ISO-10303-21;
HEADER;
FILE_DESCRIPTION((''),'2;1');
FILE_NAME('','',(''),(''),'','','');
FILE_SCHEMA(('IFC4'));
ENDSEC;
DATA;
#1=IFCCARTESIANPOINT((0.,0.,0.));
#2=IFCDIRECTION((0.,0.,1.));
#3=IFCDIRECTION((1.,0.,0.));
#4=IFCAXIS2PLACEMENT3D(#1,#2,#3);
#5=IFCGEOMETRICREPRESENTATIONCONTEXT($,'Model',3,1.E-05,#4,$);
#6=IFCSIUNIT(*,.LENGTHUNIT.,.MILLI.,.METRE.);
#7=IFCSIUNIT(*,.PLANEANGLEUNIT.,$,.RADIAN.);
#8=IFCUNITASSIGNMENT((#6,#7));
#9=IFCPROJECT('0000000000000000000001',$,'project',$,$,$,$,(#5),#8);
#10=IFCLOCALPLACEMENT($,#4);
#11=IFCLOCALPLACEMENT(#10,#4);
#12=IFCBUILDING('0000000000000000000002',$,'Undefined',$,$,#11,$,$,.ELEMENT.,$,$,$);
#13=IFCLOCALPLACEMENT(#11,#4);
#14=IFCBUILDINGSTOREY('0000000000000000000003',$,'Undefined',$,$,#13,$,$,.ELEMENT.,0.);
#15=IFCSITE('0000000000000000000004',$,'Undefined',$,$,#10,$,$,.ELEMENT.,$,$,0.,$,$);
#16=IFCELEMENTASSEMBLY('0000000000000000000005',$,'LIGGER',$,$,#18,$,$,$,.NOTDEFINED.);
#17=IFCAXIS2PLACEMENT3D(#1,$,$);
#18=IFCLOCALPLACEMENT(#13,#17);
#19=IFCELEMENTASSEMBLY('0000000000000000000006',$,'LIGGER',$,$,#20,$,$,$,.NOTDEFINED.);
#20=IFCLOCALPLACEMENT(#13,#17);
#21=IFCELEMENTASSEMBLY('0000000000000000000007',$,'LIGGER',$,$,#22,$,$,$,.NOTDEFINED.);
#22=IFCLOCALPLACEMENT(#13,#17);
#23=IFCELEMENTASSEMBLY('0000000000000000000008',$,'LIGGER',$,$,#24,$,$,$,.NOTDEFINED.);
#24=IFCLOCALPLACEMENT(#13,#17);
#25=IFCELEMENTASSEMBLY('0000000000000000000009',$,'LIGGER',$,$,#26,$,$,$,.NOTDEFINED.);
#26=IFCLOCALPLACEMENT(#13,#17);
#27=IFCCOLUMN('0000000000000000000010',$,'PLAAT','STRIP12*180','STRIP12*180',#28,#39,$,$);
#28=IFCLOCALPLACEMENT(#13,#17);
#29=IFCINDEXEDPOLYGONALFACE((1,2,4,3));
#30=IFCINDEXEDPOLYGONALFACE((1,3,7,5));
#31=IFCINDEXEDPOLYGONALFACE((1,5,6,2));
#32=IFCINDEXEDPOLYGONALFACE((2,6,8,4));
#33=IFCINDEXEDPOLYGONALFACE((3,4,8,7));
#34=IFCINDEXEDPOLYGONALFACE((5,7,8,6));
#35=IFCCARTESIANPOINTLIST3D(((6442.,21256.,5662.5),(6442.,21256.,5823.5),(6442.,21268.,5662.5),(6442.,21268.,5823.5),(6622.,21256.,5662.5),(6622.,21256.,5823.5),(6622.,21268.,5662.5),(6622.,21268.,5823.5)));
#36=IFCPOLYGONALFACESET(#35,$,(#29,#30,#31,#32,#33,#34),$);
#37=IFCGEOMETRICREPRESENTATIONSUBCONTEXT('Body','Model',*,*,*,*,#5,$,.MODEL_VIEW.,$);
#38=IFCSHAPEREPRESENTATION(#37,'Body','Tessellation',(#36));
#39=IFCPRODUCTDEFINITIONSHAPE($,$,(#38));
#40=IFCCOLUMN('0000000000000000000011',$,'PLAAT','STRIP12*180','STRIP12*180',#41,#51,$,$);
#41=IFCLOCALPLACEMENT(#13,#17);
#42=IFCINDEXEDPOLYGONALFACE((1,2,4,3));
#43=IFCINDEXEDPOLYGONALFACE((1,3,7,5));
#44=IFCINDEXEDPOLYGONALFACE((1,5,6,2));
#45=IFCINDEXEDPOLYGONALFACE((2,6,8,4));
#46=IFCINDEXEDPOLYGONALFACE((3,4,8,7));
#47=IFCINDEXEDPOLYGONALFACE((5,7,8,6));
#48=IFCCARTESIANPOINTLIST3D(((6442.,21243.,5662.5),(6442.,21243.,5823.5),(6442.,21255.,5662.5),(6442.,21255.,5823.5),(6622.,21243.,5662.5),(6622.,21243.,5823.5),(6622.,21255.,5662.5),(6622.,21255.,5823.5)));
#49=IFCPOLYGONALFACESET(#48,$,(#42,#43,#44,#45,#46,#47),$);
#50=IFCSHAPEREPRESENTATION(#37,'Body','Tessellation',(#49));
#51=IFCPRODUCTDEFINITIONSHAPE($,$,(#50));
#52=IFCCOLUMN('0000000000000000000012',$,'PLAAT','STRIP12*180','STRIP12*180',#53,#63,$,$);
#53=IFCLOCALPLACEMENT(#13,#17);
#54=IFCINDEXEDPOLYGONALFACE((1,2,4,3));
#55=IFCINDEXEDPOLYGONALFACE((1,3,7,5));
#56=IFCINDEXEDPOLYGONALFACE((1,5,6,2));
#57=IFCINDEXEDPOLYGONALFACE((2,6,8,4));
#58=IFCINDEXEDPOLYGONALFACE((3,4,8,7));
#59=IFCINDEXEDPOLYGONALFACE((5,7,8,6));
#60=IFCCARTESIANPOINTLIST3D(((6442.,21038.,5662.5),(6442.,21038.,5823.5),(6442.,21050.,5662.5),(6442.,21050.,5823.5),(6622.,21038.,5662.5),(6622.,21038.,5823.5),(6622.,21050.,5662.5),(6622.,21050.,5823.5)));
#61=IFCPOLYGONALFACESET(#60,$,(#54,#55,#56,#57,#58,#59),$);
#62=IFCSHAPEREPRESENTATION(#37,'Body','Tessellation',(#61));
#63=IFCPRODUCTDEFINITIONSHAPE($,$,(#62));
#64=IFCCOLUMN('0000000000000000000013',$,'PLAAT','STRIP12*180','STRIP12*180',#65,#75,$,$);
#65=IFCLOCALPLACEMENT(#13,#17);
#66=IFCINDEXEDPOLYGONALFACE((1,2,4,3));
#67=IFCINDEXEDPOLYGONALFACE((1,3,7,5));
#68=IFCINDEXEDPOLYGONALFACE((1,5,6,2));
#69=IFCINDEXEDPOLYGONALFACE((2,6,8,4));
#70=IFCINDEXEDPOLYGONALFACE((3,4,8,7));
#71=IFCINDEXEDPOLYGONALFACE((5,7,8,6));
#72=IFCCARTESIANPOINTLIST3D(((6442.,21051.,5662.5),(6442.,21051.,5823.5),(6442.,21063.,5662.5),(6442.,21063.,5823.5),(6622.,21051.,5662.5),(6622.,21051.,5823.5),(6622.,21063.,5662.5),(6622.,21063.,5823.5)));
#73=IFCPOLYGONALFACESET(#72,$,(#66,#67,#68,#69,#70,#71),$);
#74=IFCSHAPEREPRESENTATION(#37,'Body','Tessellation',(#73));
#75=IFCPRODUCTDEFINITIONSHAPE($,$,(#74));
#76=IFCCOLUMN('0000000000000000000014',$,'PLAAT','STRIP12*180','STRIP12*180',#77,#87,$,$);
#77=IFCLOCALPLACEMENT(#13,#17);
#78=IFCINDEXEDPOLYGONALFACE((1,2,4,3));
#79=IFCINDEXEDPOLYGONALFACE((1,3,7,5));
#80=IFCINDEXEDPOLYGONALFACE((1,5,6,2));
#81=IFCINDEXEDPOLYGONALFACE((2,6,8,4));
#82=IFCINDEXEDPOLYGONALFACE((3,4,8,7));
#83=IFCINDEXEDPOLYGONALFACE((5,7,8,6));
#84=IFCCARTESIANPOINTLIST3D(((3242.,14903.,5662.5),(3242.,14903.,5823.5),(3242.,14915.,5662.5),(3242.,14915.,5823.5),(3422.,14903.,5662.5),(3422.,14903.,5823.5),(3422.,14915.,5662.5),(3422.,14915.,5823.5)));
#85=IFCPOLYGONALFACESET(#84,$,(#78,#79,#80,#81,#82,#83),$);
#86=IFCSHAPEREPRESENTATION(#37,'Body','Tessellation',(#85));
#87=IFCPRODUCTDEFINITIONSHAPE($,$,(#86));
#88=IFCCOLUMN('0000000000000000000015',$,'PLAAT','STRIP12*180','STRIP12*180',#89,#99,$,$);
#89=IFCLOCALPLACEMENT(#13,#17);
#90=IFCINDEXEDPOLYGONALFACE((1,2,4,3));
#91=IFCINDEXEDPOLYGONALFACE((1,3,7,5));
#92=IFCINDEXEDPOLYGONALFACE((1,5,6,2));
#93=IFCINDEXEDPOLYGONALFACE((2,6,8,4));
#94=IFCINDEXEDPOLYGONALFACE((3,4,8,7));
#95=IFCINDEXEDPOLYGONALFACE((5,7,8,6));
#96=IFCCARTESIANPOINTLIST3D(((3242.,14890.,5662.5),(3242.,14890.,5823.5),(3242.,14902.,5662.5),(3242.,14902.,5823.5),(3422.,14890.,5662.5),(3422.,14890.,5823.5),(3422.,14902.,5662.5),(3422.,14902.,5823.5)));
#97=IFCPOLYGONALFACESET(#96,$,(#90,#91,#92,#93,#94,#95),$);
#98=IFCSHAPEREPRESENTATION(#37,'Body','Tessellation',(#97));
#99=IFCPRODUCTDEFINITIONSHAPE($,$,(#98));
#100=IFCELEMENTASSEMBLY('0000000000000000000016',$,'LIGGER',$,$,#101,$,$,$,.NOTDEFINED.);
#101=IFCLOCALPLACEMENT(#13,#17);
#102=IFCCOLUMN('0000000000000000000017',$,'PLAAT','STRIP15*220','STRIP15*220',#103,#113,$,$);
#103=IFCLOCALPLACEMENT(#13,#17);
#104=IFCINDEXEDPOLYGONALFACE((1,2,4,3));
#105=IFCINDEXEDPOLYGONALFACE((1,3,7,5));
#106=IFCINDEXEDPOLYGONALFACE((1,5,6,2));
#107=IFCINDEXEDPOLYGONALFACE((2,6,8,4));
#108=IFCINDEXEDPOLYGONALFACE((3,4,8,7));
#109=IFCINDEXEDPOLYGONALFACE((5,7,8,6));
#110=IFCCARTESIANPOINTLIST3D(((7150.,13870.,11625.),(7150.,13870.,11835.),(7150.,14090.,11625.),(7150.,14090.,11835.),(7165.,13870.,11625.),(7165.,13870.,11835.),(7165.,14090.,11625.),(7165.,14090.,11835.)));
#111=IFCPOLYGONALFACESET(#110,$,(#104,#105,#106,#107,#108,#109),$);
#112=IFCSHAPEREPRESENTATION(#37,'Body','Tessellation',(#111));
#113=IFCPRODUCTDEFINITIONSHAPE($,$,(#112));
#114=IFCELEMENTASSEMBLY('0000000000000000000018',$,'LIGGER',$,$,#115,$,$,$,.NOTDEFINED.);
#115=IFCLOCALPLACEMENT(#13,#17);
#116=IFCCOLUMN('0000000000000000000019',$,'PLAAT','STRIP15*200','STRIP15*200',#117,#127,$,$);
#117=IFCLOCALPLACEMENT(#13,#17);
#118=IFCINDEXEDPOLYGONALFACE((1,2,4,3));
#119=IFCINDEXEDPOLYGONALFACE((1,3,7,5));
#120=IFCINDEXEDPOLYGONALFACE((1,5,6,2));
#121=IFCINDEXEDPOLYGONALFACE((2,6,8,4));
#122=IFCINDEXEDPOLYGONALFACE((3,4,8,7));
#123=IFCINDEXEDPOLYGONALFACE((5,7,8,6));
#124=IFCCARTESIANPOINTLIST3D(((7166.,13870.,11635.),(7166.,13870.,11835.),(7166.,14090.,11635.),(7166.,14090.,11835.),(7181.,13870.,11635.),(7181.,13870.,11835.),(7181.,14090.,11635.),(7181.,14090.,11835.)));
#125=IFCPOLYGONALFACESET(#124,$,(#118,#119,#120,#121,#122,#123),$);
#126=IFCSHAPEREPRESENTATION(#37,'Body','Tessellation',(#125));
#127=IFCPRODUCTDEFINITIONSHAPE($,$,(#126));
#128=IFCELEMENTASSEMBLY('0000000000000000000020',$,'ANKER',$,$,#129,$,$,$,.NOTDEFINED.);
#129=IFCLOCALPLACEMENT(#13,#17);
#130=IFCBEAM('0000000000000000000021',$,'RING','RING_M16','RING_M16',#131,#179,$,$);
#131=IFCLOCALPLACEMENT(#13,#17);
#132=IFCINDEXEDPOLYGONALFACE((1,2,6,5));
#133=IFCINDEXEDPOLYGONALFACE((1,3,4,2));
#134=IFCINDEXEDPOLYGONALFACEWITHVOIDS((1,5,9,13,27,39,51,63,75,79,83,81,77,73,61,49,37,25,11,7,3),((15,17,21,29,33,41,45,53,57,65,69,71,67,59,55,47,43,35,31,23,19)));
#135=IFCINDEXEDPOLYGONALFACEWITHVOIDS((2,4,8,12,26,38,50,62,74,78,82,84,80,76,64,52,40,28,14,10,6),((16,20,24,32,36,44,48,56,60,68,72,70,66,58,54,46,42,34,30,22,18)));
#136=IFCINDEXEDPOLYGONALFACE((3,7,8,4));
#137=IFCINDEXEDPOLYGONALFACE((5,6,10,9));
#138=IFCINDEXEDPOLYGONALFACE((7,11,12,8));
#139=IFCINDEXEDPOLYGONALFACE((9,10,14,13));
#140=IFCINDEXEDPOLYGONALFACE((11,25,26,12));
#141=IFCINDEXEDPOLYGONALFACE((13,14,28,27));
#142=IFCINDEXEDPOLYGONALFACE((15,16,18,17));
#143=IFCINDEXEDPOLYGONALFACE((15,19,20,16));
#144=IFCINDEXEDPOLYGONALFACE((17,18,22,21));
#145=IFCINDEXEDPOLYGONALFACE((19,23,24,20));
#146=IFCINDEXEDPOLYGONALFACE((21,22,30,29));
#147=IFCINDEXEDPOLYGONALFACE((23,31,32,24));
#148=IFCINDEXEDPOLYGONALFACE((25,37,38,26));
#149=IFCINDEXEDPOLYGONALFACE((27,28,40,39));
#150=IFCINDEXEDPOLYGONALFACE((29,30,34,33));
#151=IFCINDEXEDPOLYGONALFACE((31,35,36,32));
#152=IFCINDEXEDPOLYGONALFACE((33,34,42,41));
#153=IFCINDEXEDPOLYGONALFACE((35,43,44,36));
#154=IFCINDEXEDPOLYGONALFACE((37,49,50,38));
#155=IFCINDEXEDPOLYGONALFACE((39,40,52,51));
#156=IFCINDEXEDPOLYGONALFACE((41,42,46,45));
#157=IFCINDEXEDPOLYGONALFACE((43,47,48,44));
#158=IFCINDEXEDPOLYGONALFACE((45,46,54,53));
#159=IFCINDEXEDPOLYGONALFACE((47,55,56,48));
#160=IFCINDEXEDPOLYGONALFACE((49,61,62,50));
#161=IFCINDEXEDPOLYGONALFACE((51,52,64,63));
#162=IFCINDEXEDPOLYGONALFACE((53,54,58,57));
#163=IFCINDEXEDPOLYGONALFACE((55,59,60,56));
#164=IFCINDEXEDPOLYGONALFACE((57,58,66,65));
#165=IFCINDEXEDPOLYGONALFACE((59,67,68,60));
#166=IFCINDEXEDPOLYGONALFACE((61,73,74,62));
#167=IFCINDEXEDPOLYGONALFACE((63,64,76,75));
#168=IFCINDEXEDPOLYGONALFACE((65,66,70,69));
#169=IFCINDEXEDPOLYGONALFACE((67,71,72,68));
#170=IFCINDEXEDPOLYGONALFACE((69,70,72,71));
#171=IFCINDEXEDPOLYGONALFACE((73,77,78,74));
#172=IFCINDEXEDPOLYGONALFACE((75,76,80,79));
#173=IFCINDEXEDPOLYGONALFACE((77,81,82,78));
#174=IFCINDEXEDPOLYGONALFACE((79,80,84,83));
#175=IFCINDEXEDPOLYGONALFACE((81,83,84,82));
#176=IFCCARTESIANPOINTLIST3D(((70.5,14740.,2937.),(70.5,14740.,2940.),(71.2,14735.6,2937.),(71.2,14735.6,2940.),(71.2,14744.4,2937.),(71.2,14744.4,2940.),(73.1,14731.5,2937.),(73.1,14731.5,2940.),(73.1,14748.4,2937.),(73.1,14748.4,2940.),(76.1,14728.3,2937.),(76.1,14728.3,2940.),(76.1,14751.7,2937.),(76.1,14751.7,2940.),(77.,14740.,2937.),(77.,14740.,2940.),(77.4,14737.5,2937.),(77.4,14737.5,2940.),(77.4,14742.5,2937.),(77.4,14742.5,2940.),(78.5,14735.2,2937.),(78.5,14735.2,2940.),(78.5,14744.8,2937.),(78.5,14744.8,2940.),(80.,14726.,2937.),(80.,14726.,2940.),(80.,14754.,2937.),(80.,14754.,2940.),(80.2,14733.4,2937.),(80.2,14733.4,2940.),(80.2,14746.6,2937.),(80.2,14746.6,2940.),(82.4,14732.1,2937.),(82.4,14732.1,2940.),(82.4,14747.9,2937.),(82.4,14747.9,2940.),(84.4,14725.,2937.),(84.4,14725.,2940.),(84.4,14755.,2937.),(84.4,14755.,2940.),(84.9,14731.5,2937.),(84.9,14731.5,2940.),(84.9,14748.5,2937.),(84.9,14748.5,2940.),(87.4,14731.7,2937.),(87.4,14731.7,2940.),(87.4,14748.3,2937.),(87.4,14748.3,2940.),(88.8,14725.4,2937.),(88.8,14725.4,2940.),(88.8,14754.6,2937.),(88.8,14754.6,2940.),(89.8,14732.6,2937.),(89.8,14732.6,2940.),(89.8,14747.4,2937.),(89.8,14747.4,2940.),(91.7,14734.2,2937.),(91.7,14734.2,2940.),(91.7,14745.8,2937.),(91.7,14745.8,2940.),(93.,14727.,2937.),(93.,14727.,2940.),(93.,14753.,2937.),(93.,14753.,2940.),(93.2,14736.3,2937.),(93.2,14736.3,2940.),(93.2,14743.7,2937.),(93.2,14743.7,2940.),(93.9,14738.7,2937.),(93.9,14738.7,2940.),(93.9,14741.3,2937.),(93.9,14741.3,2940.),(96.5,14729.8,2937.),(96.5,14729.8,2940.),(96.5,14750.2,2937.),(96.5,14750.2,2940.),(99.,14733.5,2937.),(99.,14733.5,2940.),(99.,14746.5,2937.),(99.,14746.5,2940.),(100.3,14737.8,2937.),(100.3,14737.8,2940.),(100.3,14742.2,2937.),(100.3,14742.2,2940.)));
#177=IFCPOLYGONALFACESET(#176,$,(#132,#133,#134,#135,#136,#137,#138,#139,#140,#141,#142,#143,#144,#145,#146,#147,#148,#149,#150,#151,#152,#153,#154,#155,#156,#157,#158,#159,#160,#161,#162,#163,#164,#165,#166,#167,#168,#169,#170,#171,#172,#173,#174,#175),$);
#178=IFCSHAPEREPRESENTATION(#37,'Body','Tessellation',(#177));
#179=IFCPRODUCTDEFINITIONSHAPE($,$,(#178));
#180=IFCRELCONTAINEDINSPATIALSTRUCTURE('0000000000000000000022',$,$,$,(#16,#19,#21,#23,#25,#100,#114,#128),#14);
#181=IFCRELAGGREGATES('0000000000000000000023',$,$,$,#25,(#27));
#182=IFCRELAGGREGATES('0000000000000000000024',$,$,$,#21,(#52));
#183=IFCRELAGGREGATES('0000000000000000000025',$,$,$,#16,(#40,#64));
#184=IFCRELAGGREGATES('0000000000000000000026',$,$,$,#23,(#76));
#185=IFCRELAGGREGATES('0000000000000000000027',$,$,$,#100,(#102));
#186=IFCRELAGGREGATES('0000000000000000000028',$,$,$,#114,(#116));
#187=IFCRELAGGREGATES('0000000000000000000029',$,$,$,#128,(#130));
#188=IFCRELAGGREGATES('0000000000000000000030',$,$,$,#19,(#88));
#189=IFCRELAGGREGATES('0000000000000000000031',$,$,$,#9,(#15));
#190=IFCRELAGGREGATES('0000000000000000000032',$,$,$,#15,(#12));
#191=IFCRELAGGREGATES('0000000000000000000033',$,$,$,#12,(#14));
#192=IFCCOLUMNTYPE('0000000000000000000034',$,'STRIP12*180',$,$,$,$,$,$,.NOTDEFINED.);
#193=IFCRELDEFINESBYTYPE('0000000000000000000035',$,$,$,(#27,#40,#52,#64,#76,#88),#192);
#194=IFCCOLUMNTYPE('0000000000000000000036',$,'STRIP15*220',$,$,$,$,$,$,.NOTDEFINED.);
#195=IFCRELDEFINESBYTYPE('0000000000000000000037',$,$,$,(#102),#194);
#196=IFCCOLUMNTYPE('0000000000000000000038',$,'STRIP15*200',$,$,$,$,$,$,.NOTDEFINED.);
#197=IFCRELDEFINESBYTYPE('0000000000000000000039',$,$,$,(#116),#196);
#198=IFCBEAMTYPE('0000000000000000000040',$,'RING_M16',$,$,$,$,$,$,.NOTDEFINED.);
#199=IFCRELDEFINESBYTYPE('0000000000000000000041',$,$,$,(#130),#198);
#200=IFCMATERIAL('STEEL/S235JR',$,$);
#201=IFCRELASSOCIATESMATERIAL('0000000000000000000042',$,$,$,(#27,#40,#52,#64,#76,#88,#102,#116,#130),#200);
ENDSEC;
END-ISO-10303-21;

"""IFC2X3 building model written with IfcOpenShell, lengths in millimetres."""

from ifc_helpers import new_model, si_unit, frame, origin_with_axes, origin_2d_with_axis, place, context, subcontext, project, spatial, rectangle, hollow_circle, extrude, material, type_object, element, aggregate, save


model = new_model("IFC2X3")

# Units and contexts
model_context = context("Model", 3, precision=1e-05, world=origin_with_axes())
body_context = subcontext(model_context, "Body", "Model", "MODEL_VIEW")
ifc_project = project(units=[si_unit("LENGTHUNIT", "METRE", prefix="MILLI"), si_unit("PLANEANGLEUNIT", "RADIAN")], contexts=[model_context])

# Site, building, storey
site_placement = place(None, origin_with_axes())
site = spatial("IfcSite", under=ifc_project, at=site_placement, Name="Undefined", CompositionType="ELEMENT", RefElevation=0.0)
building_placement = place(site_placement, origin_with_axes())
building = spatial("IfcBuilding", under=site, at=building_placement, Name="Undefined", CompositionType="ELEMENT")
storey_placement = place(building_placement, origin_with_axes())
storey = spatial("IfcBuildingStorey", under=building, at=storey_placement, Name="Undefined", CompositionType="ELEMENT", Elevation=0.0)

# Element assembly
assembly_1_placement = place(storey_placement, frame((7775.0, 21153.0, 5743.0), z_axis=(0.0, 0.0, 1.0), x_axis=(-1.0, 0.0, 0.0)))
assembly_1 = element("IfcElementAssembly", 1, at=assembly_1_placement, inside=storey, Name="LIGGER", PredefinedType="NOTDEFINED")
ifc_material = material(Name="STEEL/S235JR")

# Element assemblies
assembly_2_placement = place(storey_placement, frame((810.1, 14800.0, 5743.0), z_axis=(0.0, 0.0, 1.0), x_axis=(1.0, 0.0, 0.0)))
assembly_2 = element("IfcElementAssembly", 2, at=assembly_2_placement, inside=storey, Name="LIGGER", PredefinedType="NOTDEFINED")
column_type_1 = type_object("IfcColumnType", Name="STRIP12*180", PredefinedType="NOTDEFINED")
assembly_3_placement = place(storey_placement, frame((6532.0, 21062.1, 5743.0), z_axis=(0.0, 0.0, 1.0), x_axis=(0.0, -1.0, 0.0)))
assembly_3 = element("IfcElementAssembly", 3, at=assembly_3_placement, inside=storey, Name="LIGGER", PredefinedType="NOTDEFINED")

# Element assembly
assembly_4_placement = place(storey_placement, frame((3332.0, 21063.0, 5743.0), z_axis=(0.0, 0.0, 1.0), x_axis=(0.0, -1.0, 0.0)))
assembly_4 = element("IfcElementAssembly", 4, at=assembly_4_placement, inside=storey, Name="LIGGER", PredefinedType="NOTDEFINED")

# Element assembly, column
assembly_5_placement = place(storey_placement, frame((6532.0, 21875.0, 5743.0), z_axis=(0.0, 0.0, 1.0), x_axis=(0.0, -1.0, 0.0)))
assembly_5 = element("IfcElementAssembly", 5, at=assembly_5_placement, inside=storey, Name="LIGGER", PredefinedType="NOTDEFINED")
column_1_placement = place(storey_placement, frame((6532.0, 21262.0, 5662.5), z_axis=(0.0, 0.0, 1.0), x_axis=(1.0, 0.0, 0.0)))
column_1 = element("IfcColumn", 6, at=column_1_placement, type_object=column_type_1, material=ifc_material, Name="PLAAT", Description="STRIP12*180", ObjectType="STRIP12*180", context=body_context, shape_type="SweptSolid", body=[
    extrude(rectangle(XDim=12.0, YDim=180.0, at=origin_2d_with_axis()), frame((0.0, 0.0, 161.0), z_axis=(0.0, 0.0, -1.0), x_axis=(0.0, 1.0, 0.0)), (0.0, 0.0, 1.0), 161.0),
])
aggregate(assembly_5, [column_1])

# Columns
column_2_placement = place(storey_placement, frame((6532.0, 21249.0, 5662.5), z_axis=(0.0, 0.0, 1.0), x_axis=(1.0, 0.0, 0.0)))
column_2 = element("IfcColumn", 7, at=column_2_placement, type_object=column_type_1, material=ifc_material, Name="PLAAT", Description="STRIP12*180", ObjectType="STRIP12*180", context=body_context, shape_type="SweptSolid", body=[
    extrude(rectangle(XDim=12.0, YDim=180.0, at=origin_2d_with_axis()), frame((0.0, 0.0, 161.0), z_axis=(0.0, 0.0, -1.0), x_axis=(0.0, 1.0, 0.0)), (0.0, 0.0, 1.0), 161.0),
])
column_3_placement = place(storey_placement, frame((6532.0, 21044.0, 5662.5), z_axis=(0.0, 0.0, 1.0), x_axis=(1.0, 0.0, 0.0)))
column_3 = element("IfcColumn", 8, at=column_3_placement, type_object=column_type_1, material=ifc_material, Name="PLAAT", Description="STRIP12*180", ObjectType="STRIP12*180", context=body_context, shape_type="SweptSolid", body=[
    extrude(rectangle(XDim=12.0, YDim=180.0, at=origin_2d_with_axis()), frame((0.0, 0.0, 161.0), z_axis=(0.0, 0.0, -1.0), x_axis=(0.0, -1.0, 0.0)), (0.0, 0.0, 1.0), 161.0),
])
aggregate(assembly_3, [column_3])
column_4_placement = place(storey_placement, frame((6532.0, 21057.0, 5662.5), z_axis=(0.0, 0.0, 1.0), x_axis=(1.0, 0.0, 0.0)))
column_4 = element("IfcColumn", 9, at=column_4_placement, type_object=column_type_1, material=ifc_material, Name="PLAAT", Description="STRIP12*180", ObjectType="STRIP12*180", context=body_context, shape_type="SweptSolid", body=[
    extrude(rectangle(XDim=12.0, YDim=180.0, at=origin_2d_with_axis()), frame((0.0, 0.0, 161.0), z_axis=(0.0, 0.0, -1.0), x_axis=(0.0, -1.0, 0.0)), (0.0, 0.0, 1.0), 161.0),
])
aggregate(assembly_1, [column_2, column_4])
column_5_placement = place(storey_placement, frame((3332.0, 14909.0, 5662.5), z_axis=(0.0, 0.0, 1.0), x_axis=(1.0, 0.0, 0.0)))
column_5 = element("IfcColumn", 10, at=column_5_placement, type_object=column_type_1, material=ifc_material, Name="PLAAT", Description="STRIP12*180", ObjectType="STRIP12*180", context=body_context, shape_type="SweptSolid", body=[
    extrude(rectangle(XDim=12.0, YDim=180.0, at=origin_2d_with_axis()), frame((0.0, 0.0, 161.0), z_axis=(0.0, 0.0, -1.0), x_axis=(0.0, 1.0, 0.0)), (0.0, 0.0, 1.0), 161.0),
])
aggregate(assembly_4, [column_5])
column_6_placement = place(storey_placement, frame((3332.0, 14896.0, 5662.5), z_axis=(0.0, 0.0, 1.0), x_axis=(1.0, 0.0, 0.0)))
column_6 = element("IfcColumn", 11, at=column_6_placement, type_object=column_type_1, material=ifc_material, Name="PLAAT", Description="STRIP12*180", ObjectType="STRIP12*180", context=body_context, shape_type="SweptSolid", body=[
    extrude(rectangle(XDim=12.0, YDim=180.0, at=origin_2d_with_axis()), frame((0.0, 0.0, 161.0), z_axis=(0.0, 0.0, -1.0), x_axis=(0.0, 1.0, 0.0)), (0.0, 0.0, 1.0), 161.0),
])

# Element assemblies, columns
assembly_6_placement = place(storey_placement, frame((7040.0, 14090.0, 11730.0), z_axis=(0.0, 0.0, 1.0), x_axis=(0.0, -1.0, 0.0)))
assembly_6 = element("IfcElementAssembly", 12, at=assembly_6_placement, inside=storey, Name="LIGGER", PredefinedType="NOTDEFINED")
column_type_2 = type_object("IfcColumnType", Name="STRIP15*220", PredefinedType="NOTDEFINED")
column_7_placement = place(storey_placement, frame((7157.5, 13980.0, 11625.0), z_axis=(0.0, 0.0, 1.0), x_axis=(1.0, 0.0, 0.0)))
column_7 = element("IfcColumn", 13, at=column_7_placement, type_object=column_type_2, material=ifc_material, Name="PLAAT", Description="STRIP15*220", ObjectType="STRIP15*220", context=body_context, shape_type="SweptSolid", body=[
    extrude(rectangle(XDim=15.0, YDim=220.0, at=origin_2d_with_axis()), frame((0.0, 0.0, 210.0), z_axis=(0.0, 0.0, -1.0), x_axis=(1.0, 0.0, 0.0)), (0.0, 0.0, 1.0), 210.0),
])
aggregate(assembly_6, [column_7])
assembly_7_placement = place(storey_placement, frame((7150.0, 13980.0, 11735.0), z_axis=(0.0, 0.0, 1.0), x_axis=(1.0, 0.0, 0.0)))
assembly_7 = element("IfcElementAssembly", 14, at=assembly_7_placement, inside=storey, Name="LIGGER", PredefinedType="NOTDEFINED")
column_type_3 = type_object("IfcColumnType", Name="STRIP15*200", PredefinedType="NOTDEFINED")
column_8_placement = place(storey_placement, frame((7173.5, 13980.0, 11635.0), z_axis=(0.0, 0.0, 1.0), x_axis=(1.0, 0.0, 0.0)))
column_8 = element("IfcColumn", 15, at=column_8_placement, type_object=column_type_3, material=ifc_material, Name="PLAAT", Description="STRIP15*200", ObjectType="STRIP15*200", context=body_context, shape_type="SweptSolid", body=[
    extrude(rectangle(XDim=15.0, YDim=220.0, at=origin_2d_with_axis()), frame((0.0, 0.0, 200.0), z_axis=(0.0, 0.0, -1.0), x_axis=(1.0, 0.0, 0.0)), (0.0, 0.0, 1.0), 200.0),
])
aggregate(assembly_7, [column_8])

# Element assembly, beam
assembly_8_placement = place(storey_placement, frame((85.5, 14740.0, 2995.0), z_axis=(0.0, -1.0, 0.0), x_axis=(0.0, 0.0, -1.0)))
assembly_8 = element("IfcElementAssembly", 16, at=assembly_8_placement, inside=storey, Name="ANKER", PredefinedType="NOTDEFINED")
beam_type_1 = type_object("IfcBeamType", Name="RING_M16", PredefinedType="NOTDEFINED")
beam_1_placement = place(storey_placement, frame((85.5, 14740.0, 2940.0), z_axis=(0.0, -1.0, 0.0), x_axis=(0.0, 0.0, -1.0)))
beam_1 = element("IfcBeam", 17, at=beam_1_placement, type_object=beam_type_1, material=ifc_material, Name="RING", Description="RING_M16", ObjectType="RING_M16", context=body_context, shape_type="SweptSolid", body=[
    extrude(hollow_circle(Radius=15.0, WallThickness=6.5, at=origin_2d_with_axis()), frame((3.0, 0.0, 0.0), z_axis=(-1.0, 0.0, 0.0), x_axis=(0.0, -1.0, 0.0)), (0.0, 0.0, 1.0), 3.0),
])
aggregate(assembly_8, [beam_1])

aggregate(assembly_2, [column_6])

save(model, "model.ifc")
